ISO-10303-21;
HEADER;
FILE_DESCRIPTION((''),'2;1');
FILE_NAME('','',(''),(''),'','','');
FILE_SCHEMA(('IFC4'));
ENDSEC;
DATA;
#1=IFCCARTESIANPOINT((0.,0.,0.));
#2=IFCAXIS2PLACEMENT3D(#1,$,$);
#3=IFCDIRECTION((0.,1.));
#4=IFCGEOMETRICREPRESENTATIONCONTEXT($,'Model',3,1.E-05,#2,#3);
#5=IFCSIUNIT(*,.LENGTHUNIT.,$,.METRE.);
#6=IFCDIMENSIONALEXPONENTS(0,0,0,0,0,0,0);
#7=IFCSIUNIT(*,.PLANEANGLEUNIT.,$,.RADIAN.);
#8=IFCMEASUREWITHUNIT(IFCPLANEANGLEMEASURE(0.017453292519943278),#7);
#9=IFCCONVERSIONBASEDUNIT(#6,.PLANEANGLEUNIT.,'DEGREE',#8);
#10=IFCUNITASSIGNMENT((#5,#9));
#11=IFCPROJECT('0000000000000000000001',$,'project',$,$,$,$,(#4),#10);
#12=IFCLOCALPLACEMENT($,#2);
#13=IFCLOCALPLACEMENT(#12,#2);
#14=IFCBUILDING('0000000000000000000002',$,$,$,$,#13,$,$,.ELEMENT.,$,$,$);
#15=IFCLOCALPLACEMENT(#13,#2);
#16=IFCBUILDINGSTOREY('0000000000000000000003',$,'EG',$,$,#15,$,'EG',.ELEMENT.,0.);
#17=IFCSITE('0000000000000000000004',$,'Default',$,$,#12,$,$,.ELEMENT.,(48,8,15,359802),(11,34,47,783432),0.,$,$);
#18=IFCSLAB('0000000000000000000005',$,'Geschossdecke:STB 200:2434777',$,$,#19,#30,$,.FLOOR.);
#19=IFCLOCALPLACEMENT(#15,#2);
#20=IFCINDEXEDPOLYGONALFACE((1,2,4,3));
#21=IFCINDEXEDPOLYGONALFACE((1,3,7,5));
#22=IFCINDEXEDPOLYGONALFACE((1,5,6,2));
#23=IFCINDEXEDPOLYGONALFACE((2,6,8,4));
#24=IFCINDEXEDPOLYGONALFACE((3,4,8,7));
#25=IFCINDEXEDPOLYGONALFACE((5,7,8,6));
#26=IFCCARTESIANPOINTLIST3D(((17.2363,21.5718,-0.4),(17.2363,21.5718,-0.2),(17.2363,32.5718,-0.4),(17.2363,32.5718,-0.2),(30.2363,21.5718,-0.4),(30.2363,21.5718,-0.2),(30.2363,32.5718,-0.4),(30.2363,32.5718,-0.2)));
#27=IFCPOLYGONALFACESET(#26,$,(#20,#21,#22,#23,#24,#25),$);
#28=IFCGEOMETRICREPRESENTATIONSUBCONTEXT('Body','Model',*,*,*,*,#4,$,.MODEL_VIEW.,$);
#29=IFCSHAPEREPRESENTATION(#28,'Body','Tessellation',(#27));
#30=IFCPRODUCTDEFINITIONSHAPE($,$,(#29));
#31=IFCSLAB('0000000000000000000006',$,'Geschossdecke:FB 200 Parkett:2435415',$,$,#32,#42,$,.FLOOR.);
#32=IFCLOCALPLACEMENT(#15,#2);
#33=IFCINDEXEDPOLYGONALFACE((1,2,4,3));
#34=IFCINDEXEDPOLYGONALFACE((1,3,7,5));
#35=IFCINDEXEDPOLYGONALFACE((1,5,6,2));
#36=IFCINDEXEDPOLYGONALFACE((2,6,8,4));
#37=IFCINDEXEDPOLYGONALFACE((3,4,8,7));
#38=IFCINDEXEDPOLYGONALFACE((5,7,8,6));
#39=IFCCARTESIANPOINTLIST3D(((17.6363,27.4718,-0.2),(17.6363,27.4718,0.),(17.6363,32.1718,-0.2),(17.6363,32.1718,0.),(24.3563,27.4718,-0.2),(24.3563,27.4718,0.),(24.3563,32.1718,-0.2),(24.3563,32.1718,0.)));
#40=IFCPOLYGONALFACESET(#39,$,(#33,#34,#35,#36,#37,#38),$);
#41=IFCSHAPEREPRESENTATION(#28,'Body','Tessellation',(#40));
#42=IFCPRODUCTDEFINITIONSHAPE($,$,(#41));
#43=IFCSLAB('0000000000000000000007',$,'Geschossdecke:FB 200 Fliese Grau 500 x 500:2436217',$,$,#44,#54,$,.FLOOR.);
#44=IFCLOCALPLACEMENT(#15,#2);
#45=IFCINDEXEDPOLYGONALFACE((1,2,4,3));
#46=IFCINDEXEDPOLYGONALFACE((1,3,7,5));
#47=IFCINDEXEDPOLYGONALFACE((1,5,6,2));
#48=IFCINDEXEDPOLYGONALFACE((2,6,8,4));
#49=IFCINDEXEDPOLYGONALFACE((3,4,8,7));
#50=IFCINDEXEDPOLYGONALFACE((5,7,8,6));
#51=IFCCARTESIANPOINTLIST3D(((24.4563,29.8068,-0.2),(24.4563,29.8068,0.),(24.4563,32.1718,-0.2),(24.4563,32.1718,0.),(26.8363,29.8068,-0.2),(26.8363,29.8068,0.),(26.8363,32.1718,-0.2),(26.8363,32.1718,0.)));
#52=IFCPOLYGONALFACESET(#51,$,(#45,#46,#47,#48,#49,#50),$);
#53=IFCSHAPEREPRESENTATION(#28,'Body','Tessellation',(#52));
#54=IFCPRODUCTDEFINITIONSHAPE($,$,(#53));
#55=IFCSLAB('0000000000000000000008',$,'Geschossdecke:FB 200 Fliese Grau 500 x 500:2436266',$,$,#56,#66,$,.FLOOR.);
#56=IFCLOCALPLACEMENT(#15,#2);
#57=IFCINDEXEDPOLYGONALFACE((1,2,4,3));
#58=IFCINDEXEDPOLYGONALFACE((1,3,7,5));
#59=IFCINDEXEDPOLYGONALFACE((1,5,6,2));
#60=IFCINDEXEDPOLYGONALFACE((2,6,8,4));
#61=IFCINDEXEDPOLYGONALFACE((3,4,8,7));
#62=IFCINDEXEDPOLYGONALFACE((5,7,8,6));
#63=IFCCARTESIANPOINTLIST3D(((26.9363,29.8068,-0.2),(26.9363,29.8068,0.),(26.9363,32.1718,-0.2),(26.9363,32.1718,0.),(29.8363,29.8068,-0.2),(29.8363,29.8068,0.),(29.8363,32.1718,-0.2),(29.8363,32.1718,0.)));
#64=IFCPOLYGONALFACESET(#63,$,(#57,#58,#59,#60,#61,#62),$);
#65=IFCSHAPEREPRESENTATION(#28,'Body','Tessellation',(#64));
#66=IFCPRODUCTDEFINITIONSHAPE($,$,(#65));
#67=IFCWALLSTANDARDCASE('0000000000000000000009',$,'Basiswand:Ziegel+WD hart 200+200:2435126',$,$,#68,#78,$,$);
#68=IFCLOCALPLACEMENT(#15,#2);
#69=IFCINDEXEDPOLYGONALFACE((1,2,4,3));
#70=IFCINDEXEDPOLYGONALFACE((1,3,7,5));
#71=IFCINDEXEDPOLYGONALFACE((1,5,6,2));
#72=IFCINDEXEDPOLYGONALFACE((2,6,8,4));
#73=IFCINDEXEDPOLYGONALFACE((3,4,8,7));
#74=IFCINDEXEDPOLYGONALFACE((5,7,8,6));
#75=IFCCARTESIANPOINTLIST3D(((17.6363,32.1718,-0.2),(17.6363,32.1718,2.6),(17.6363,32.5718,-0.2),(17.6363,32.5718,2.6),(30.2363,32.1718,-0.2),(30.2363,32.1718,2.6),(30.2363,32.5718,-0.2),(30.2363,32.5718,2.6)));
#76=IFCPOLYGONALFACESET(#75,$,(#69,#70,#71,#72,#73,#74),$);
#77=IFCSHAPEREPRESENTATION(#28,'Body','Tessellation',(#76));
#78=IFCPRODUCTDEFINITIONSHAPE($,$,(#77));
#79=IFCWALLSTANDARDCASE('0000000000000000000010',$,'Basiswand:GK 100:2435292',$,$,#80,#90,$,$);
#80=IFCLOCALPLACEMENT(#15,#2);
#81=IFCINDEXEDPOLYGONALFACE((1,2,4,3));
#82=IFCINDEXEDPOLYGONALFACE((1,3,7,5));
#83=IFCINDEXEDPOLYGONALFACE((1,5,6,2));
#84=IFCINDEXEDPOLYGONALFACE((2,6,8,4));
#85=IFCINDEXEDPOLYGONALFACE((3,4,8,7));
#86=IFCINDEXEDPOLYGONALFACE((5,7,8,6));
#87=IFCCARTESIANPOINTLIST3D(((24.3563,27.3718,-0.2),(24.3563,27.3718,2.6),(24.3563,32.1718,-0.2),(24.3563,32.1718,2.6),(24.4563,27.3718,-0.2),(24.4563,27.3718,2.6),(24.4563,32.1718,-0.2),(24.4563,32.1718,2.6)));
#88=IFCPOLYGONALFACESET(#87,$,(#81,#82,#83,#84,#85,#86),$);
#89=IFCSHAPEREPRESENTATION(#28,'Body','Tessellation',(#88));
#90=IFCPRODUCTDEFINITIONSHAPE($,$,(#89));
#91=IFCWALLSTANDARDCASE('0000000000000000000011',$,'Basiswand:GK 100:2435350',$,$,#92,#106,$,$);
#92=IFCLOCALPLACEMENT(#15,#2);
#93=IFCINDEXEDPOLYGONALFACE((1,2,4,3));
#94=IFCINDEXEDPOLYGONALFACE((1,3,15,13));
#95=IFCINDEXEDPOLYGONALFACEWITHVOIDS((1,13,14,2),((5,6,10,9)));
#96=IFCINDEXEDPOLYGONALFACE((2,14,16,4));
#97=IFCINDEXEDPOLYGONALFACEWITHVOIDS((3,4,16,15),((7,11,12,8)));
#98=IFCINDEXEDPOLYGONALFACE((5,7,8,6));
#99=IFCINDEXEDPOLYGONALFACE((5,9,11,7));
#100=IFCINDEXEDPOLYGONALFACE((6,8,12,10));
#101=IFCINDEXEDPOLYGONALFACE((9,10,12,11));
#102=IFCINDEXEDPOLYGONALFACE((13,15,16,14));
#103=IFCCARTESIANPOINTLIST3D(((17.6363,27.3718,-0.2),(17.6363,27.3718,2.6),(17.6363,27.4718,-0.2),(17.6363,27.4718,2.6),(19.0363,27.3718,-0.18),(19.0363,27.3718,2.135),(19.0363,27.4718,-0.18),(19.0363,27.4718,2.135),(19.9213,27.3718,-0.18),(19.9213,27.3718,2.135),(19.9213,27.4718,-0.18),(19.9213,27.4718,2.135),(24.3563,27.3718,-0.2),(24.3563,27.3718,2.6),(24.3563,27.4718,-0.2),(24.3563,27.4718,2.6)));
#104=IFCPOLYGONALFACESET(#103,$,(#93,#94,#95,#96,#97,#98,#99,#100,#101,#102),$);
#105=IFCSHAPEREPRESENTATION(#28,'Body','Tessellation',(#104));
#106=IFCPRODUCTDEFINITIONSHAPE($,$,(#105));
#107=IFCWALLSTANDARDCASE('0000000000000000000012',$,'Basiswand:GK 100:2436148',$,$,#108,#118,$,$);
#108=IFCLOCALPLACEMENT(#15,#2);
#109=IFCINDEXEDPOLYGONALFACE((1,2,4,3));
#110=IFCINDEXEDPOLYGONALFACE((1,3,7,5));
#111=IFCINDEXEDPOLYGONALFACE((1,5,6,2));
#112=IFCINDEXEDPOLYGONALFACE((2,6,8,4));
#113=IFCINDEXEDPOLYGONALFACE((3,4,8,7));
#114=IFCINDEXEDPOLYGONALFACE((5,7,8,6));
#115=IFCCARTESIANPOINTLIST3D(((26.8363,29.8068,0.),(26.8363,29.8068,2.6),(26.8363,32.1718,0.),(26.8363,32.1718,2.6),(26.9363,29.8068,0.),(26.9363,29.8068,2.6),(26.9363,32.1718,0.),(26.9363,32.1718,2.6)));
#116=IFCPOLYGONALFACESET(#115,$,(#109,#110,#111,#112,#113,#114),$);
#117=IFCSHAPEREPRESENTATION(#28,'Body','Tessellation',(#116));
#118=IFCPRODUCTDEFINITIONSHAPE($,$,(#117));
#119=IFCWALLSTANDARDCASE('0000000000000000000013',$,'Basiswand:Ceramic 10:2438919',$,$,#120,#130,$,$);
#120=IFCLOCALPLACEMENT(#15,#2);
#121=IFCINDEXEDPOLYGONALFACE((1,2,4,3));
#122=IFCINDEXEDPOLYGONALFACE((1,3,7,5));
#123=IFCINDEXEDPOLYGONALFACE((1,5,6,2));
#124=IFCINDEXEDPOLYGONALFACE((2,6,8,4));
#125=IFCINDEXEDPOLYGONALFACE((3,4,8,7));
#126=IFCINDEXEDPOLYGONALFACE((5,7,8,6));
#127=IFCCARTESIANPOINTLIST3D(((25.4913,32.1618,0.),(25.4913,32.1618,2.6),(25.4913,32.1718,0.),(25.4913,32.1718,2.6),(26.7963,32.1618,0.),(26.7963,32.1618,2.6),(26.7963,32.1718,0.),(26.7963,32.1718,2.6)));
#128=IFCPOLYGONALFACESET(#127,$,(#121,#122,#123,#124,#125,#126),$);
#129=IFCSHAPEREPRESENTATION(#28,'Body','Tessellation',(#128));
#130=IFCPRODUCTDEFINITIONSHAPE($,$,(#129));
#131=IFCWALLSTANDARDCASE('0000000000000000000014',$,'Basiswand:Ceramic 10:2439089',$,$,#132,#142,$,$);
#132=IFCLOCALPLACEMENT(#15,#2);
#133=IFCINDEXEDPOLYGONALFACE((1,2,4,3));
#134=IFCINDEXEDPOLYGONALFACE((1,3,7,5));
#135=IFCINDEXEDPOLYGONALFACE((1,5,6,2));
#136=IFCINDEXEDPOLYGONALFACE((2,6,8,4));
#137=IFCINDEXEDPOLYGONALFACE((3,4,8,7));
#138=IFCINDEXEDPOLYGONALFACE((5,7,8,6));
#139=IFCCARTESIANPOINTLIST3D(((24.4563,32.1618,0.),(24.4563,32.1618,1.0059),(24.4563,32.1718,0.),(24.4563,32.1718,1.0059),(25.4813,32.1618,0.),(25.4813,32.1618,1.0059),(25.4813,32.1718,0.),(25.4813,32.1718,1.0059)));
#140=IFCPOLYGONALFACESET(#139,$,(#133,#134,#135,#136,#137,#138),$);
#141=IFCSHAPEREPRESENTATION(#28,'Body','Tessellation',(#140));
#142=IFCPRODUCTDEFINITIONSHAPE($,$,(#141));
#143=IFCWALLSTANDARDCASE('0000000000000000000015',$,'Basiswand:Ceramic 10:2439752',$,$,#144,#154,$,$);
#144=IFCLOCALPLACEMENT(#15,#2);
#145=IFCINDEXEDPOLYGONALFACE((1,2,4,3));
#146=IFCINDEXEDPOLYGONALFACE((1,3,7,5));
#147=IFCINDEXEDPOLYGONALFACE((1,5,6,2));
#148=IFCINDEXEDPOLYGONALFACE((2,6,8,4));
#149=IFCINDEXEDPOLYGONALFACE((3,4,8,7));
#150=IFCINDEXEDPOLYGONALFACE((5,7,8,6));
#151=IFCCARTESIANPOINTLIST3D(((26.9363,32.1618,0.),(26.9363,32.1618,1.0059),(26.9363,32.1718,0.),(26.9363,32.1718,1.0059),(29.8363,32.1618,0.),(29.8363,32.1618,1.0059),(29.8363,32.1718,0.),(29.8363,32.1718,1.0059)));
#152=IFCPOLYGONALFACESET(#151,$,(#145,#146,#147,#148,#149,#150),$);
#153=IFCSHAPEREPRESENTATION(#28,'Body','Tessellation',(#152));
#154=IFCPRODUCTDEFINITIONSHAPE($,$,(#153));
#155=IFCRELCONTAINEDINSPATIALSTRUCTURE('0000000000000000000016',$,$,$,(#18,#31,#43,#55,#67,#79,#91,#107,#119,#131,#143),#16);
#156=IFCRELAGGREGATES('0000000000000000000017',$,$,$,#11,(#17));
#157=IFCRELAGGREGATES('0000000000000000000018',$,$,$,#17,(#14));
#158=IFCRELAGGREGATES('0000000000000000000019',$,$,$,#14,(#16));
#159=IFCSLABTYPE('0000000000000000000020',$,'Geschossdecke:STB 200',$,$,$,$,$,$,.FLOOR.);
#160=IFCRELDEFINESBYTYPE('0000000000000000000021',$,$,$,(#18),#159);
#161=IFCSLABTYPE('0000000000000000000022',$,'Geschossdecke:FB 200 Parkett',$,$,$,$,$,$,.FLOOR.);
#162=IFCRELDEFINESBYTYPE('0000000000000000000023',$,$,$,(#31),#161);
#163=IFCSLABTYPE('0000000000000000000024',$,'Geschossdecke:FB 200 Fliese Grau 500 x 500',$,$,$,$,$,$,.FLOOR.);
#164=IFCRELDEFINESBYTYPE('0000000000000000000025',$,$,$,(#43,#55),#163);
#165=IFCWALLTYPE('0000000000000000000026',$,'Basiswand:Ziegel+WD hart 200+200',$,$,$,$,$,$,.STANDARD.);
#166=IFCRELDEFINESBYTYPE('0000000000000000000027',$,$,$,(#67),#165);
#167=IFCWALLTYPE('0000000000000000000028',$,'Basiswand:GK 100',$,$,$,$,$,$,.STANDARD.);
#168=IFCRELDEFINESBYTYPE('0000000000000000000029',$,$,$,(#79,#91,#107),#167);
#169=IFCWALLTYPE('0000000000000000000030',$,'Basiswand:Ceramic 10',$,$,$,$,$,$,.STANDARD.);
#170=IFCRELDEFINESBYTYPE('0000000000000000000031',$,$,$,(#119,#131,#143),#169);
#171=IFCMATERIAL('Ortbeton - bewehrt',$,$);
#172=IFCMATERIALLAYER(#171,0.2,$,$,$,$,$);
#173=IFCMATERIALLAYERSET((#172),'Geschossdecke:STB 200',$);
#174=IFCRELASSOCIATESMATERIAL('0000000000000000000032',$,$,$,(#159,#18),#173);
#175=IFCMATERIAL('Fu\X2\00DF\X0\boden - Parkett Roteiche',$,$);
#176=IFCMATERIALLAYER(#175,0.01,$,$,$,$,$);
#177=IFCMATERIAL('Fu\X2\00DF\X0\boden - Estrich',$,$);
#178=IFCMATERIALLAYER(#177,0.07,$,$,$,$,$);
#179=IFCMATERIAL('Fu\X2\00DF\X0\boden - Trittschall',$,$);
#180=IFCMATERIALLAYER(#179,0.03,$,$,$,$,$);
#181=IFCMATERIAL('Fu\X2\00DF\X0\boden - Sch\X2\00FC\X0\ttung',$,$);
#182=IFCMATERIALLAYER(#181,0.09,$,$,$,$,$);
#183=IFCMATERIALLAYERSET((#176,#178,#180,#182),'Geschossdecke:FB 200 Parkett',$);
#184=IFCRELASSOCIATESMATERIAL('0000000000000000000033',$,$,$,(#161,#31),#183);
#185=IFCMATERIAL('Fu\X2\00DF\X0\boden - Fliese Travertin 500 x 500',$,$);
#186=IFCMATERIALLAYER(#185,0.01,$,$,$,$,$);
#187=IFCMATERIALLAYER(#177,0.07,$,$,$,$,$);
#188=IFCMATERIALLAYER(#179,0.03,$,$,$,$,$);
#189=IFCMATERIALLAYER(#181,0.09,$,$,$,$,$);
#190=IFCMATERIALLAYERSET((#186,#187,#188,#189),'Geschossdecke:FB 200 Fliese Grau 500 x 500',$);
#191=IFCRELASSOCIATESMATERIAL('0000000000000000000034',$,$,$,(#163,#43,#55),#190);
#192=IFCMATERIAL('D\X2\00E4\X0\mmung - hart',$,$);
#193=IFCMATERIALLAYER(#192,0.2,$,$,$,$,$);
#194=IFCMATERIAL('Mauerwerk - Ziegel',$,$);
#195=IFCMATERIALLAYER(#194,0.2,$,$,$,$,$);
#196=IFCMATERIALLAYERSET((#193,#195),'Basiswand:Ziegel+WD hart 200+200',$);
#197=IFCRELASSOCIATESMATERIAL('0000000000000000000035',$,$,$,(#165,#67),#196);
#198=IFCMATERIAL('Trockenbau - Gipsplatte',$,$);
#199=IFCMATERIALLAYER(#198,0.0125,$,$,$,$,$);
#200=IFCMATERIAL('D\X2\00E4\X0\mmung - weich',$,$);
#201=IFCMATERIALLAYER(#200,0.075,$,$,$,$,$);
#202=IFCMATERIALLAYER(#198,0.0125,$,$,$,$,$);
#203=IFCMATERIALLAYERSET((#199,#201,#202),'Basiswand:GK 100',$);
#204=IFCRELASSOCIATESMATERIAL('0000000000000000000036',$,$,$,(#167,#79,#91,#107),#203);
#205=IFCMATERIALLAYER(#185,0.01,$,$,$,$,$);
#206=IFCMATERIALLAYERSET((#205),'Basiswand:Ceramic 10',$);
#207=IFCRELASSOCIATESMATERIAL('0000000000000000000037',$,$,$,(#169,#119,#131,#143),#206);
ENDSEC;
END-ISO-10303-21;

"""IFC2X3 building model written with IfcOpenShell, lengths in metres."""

from ifc_helpers import new_model, entity, si_unit, converted_unit, direction, frame, frame_2d, origin, origin_2d_with_axis, place, context, subcontext, project, spatial, rectangle, extrude, material, layer, layer_set, layer_usage, type_object, element, save


model = new_model("IFC2X3")

# Units and contexts
model_context = context("Model", 3, precision=1e-05, world=origin(), true_north=direction((0.0, 1.0)))
body_context = subcontext(model_context, "Body", "Model", "MODEL_VIEW")
ifc_project = project(units=[si_unit("LENGTHUNIT", "METRE"), converted_unit("PLANEANGLEUNIT", "DEGREE", entity("IfcPlaneAngleMeasure", 0.017453292519943278), si_unit("PLANEANGLEUNIT", "RADIAN"), dimensions=[0, 0, 0, 0, 0, 0, 0])], contexts=[model_context])

# Site, building, storey
site_placement = place(None, origin())
site = spatial("IfcSite", under=ifc_project, at=site_placement, Name="Default", CompositionType="ELEMENT", RefLatitude=(48, 8, 15, 359802), RefLongitude=(11, 34, 47, 783432), RefElevation=0.0)
building_placement = place(site_placement, origin())
building = spatial("IfcBuilding", under=site, at=building_placement, CompositionType="ELEMENT")
storey_placement = place(building_placement, origin())
storey = spatial("IfcBuildingStorey", under=building, at=storey_placement, Name="EG", LongName="EG", CompositionType="ELEMENT", Elevation=0.0)

# Slabs
ifc_material_1 = material(Name="Ortbeton - bewehrt")
ifc_layer_1 = layer(ifc_material_1, 0.2)
ifc_layer_set_1 = layer_set([ifc_layer_1], Name="Geschossdecke:STB 200")
ifc_layer_usage_1 = layer_usage(ifc_layer_set_1, "AXIS3", "POSITIVE", 0.0)
slab_type_1 = type_object("IfcSlabType", Name="Geschossdecke:STB 200", PredefinedType="FLOOR", material=ifc_layer_set_1)
slab_1_placement = place(storey_placement, origin())
element("IfcSlab", 1, at=slab_1_placement, inside=storey, type_object=slab_type_1, material=ifc_layer_usage_1, Name="Geschossdecke:STB 200:2434777", PredefinedType="FLOOR", context=body_context, shape_type="SweptSolid", body=[
    extrude(rectangle(XDim=11.0, YDim=13.0, at=origin_2d_with_axis()), frame((23.7363, 27.0718, -0.2), z_axis=(0.0, 0.0, -1.0), x_axis=(0.0, 1.0, 0.0)), (0.0, 0.0, 1.0), 0.2),
])
ifc_material_2 = material(Name="Fußboden - Parkett Roteiche")
ifc_layer_2 = layer(ifc_material_2, 0.01)
ifc_material_3 = material(Name="Fußboden - Estrich")
ifc_layer_3 = layer(ifc_material_3, 0.07)
ifc_material_4 = material(Name="Fußboden - Trittschall")
ifc_layer_4 = layer(ifc_material_4, 0.03)
ifc_material_5 = material(Name="Fußboden - Schüttung")
ifc_layer_5 = layer(ifc_material_5, 0.09)
ifc_layer_set_2 = layer_set([ifc_layer_2, ifc_layer_3, ifc_layer_4, ifc_layer_5], Name="Geschossdecke:FB 200 Parkett")
ifc_layer_usage_2 = layer_usage(ifc_layer_set_2, "AXIS3", "POSITIVE", 0.0)
slab_type_2 = type_object("IfcSlabType", Name="Geschossdecke:FB 200 Parkett", PredefinedType="FLOOR", material=ifc_layer_set_2)
slab_2_placement = place(storey_placement, origin())
element("IfcSlab", 2, at=slab_2_placement, inside=storey, type_object=slab_type_2, material=ifc_layer_usage_2, Name="Geschossdecke:FB 200 Parkett:2435415", PredefinedType="FLOOR", context=body_context, shape_type="SweptSolid", body=[
    extrude(rectangle(XDim=4.7, YDim=6.72, at=frame_2d((0.0, 0.0), x_axis=(1.0, 0.0))), frame((20.9963, 29.8218, 0.0), z_axis=(0.0, 0.0, -1.0), x_axis=(0.0, 1.0, 0.0)), (0.0, 0.0, 1.0), 0.2),
])
ifc_material_6 = material(Name="Fußboden - Fliese Travertin 500 x 500")
ifc_layer_6 = layer(ifc_material_6, 0.01)
ifc_layer_7 = layer(ifc_material_3, 0.07)
ifc_layer_8 = layer(ifc_material_4, 0.03)
ifc_layer_9 = layer(ifc_material_5, 0.09)
ifc_layer_set_3 = layer_set([ifc_layer_6, ifc_layer_7, ifc_layer_8, ifc_layer_9], Name="Geschossdecke:FB 200 Fliese Grau 500 x 500")
ifc_layer_usage_3 = layer_usage(ifc_layer_set_3, "AXIS3", "POSITIVE", 0.0)
slab_type_3 = type_object("IfcSlabType", Name="Geschossdecke:FB 200 Fliese Grau 500 x 500", PredefinedType="FLOOR", material=ifc_layer_set_3)
slab_3_placement = place(storey_placement, origin())
element("IfcSlab", 3, at=slab_3_placement, inside=storey, type_object=slab_type_3, material=ifc_layer_usage_3, Name="Geschossdecke:FB 200 Fliese Grau 500 x 500:2436217", PredefinedType="FLOOR", context=body_context, shape_type="SweptSolid", body=[
    extrude(rectangle(XDim=2.365, YDim=2.38, at=frame_2d((0.0, 0.0), x_axis=(1.0, 0.0))), frame((25.6463, 30.9893, 0.0), z_axis=(0.0, 0.0, -1.0), x_axis=(0.0, 1.0, 0.0)), (0.0, 0.0, 1.0), 0.2),
])
ifc_layer_usage_4 = layer_usage(ifc_layer_set_3, "AXIS3", "POSITIVE", 0.0)
slab_4_placement = place(storey_placement, origin())
element("IfcSlab", 4, at=slab_4_placement, inside=storey, type_object=slab_type_3, material=ifc_layer_usage_4, Name="Geschossdecke:FB 200 Fliese Grau 500 x 500:2436266", PredefinedType="FLOOR", context=body_context, shape_type="SweptSolid", body=[
    extrude(rectangle(XDim=2.365, YDim=2.9, at=frame_2d((0.0, 0.0), x_axis=(1.0, 0.0))), frame((28.3863, 30.9893, 0.0), z_axis=(0.0, 0.0, -1.0), x_axis=(0.0, 1.0, 0.0)), (0.0, 0.0, 1.0), 0.2),
])

# Walls
ifc_material_7 = material(Name="Dämmung - hart")
ifc_layer_10 = layer(ifc_material_7, 0.2)
ifc_material_8 = material(Name="Mauerwerk - Ziegel")
ifc_layer_11 = layer(ifc_material_8, 0.2)
ifc_layer_set_4 = layer_set([ifc_layer_10, ifc_layer_11], Name="Basiswand:Ziegel+WD hart 200+200")
ifc_layer_usage_5 = layer_usage(ifc_layer_set_4, "AXIS2", "NEGATIVE", 0.2)
wall_type_1 = type_object("IfcWallType", Name="Basiswand:Ziegel+WD hart 200+200", PredefinedType="STANDARD", material=ifc_layer_set_4)
wall_1_placement = place(storey_placement, frame((17.6363, 32.3718, -0.2)))
element("IfcWallStandardCase", 5, at=wall_1_placement, inside=storey, type_object=wall_type_1, material=ifc_layer_usage_5, Name="Basiswand:Ziegel+WD hart 200+200:2435126", context=body_context, shape_type="SweptSolid", body=[
    extrude(rectangle(XDim=12.6, YDim=0.4, at=frame_2d((6.3, 0.0), x_axis=(-1.0, 0.0))), origin(), (0.0, 0.0, 1.0), 2.8),
])
ifc_material_9 = material(Name="Trockenbau - Gipsplatte")
ifc_layer_12 = layer(ifc_material_9, 0.0125)
ifc_material_10 = material(Name="Dämmung - weich")
ifc_layer_13 = layer(ifc_material_10, 0.075)
ifc_layer_14 = layer(ifc_material_9, 0.0125)
ifc_layer_set_5 = layer_set([ifc_layer_12, ifc_layer_13, ifc_layer_14], Name="Basiswand:GK 100")
ifc_layer_usage_6 = layer_usage(ifc_layer_set_5, "AXIS2", "NEGATIVE", 0.05)
wall_type_2 = type_object("IfcWallType", Name="Basiswand:GK 100", PredefinedType="STANDARD", material=ifc_layer_set_5)
wall_2_placement = place(storey_placement, frame((24.4063, 32.1718, -0.2), z_axis=(0.0, 0.0, 1.0), x_axis=(0.0, -1.0, 0.0)))
element("IfcWallStandardCase", 6, at=wall_2_placement, inside=storey, type_object=wall_type_2, material=ifc_layer_usage_6, Name="Basiswand:GK 100:2435292", context=body_context, shape_type="SweptSolid", body=[
    extrude(rectangle(XDim=4.8, YDim=0.1, at=frame_2d((2.4, 0.0), x_axis=(-1.0, 0.0))), origin(), (0.0, 0.0, 1.0), 2.8),
])

# Wall, opening
ifc_layer_usage_7 = layer_usage(ifc_layer_set_5, "AXIS2", "NEGATIVE", 0.05)
wall_3_placement = place(storey_placement, frame((24.3563, 27.4218, -0.2), z_axis=(0.0, 0.0, 1.0), x_axis=(-1.0, 0.0, 0.0)))
wall_3 = element("IfcWallStandardCase", 7, at=wall_3_placement, inside=storey, type_object=wall_type_2, material=ifc_layer_usage_7, Name="Basiswand:GK 100:2435350", context=body_context, shape_type="SweptSolid", body=[
    extrude(rectangle(XDim=6.72, YDim=0.1, at=frame_2d((3.36, 0.0), x_axis=(-1.0, 0.0))), origin(), (0.0, 0.0, 1.0), 2.8),
])
opening_1_placement = place(wall_3_placement, frame((4.435, -0.05, 0.02)))
element("IfcOpeningElement", 8, at=opening_1_placement, cuts=wall_3, ObjectType="Opening", context=body_context, shape_type="SweptSolid", body=[
    extrude(rectangle(XDim=2.315, YDim=0.885, at=frame_2d((1.1575, 0.4425), x_axis=(-1.0, 0.0))), frame((0.0, 0.0, 0.0), z_axis=(0.0, 1.0, 0.0), x_axis=(0.0, 0.0, 1.0)), (0.0, 0.0, 1.0), 0.1),
])

# Walls
ifc_layer_usage_8 = layer_usage(ifc_layer_set_5, "AXIS2", "NEGATIVE", 0.05)
wall_4_placement = place(storey_placement, frame((26.8863, 29.8068, 0.0), z_axis=(0.0, 0.0, 1.0), x_axis=(0.0, 1.0, 0.0)))
element("IfcWallStandardCase", 9, at=wall_4_placement, inside=storey, type_object=wall_type_2, material=ifc_layer_usage_8, Name="Basiswand:GK 100:2436148", context=body_context, shape_type="SweptSolid", body=[
    extrude(rectangle(XDim=2.365, YDim=0.1, at=frame_2d((1.1825, 0.0), x_axis=(-1.0, 0.0))), origin(), (0.0, 0.0, 1.0), 2.6),
])
ifc_layer_15 = layer(ifc_material_6, 0.01)
ifc_layer_set_6 = layer_set([ifc_layer_15], Name="Basiswand:Ceramic 10")
ifc_layer_usage_9 = layer_usage(ifc_layer_set_6, "AXIS2", "NEGATIVE", 0.005)
wall_type_3 = type_object("IfcWallType", Name="Basiswand:Ceramic 10", PredefinedType="STANDARD", material=ifc_layer_set_6)
wall_5_placement = place(storey_placement, frame((26.7963, 32.1668, 0.0), z_axis=(0.0, 0.0, 1.0), x_axis=(-1.0, 0.0, 0.0)))
element("IfcWallStandardCase", 10, at=wall_5_placement, inside=storey, type_object=wall_type_3, material=ifc_layer_usage_9, Name="Basiswand:Ceramic 10:2438919", context=body_context, shape_type="SweptSolid", body=[
    extrude(rectangle(XDim=1.305, YDim=0.01, at=frame_2d((0.6525, 0.0), x_axis=(-1.0, 0.0))), origin(), (0.0, 0.0, 1.0), 2.6),
])
ifc_layer_usage_10 = layer_usage(ifc_layer_set_6, "AXIS2", "POSITIVE", -0.005)
wall_6_placement = place(storey_placement, frame((24.4563, 32.1668, 0.0)))
element("IfcWallStandardCase", 11, at=wall_6_placement, inside=storey, type_object=wall_type_3, material=ifc_layer_usage_10, Name="Basiswand:Ceramic 10:2439089", context=body_context, shape_type="SweptSolid", body=[
    extrude(rectangle(XDim=1.025, YDim=0.01, at=frame_2d((0.5125, 0.0), x_axis=(-1.0, 0.0))), origin(), (0.0, 0.0, 1.0), 1.0059),
])
ifc_layer_usage_11 = layer_usage(ifc_layer_set_6, "AXIS2", "POSITIVE", -0.005)
wall_7_placement = place(storey_placement, frame((26.9363, 32.1668, 0.0)))
element("IfcWallStandardCase", 12, at=wall_7_placement, inside=storey, type_object=wall_type_3, material=ifc_layer_usage_11, Name="Basiswand:Ceramic 10:2439752", context=body_context, shape_type="SweptSolid", body=[
    extrude(rectangle(XDim=2.9, YDim=0.01, at=frame_2d((1.45, 0.0), x_axis=(-1.0, 0.0))), origin(), (0.0, 0.0, 1.0), 1.0059),
])

save(model, "model.ifc")
